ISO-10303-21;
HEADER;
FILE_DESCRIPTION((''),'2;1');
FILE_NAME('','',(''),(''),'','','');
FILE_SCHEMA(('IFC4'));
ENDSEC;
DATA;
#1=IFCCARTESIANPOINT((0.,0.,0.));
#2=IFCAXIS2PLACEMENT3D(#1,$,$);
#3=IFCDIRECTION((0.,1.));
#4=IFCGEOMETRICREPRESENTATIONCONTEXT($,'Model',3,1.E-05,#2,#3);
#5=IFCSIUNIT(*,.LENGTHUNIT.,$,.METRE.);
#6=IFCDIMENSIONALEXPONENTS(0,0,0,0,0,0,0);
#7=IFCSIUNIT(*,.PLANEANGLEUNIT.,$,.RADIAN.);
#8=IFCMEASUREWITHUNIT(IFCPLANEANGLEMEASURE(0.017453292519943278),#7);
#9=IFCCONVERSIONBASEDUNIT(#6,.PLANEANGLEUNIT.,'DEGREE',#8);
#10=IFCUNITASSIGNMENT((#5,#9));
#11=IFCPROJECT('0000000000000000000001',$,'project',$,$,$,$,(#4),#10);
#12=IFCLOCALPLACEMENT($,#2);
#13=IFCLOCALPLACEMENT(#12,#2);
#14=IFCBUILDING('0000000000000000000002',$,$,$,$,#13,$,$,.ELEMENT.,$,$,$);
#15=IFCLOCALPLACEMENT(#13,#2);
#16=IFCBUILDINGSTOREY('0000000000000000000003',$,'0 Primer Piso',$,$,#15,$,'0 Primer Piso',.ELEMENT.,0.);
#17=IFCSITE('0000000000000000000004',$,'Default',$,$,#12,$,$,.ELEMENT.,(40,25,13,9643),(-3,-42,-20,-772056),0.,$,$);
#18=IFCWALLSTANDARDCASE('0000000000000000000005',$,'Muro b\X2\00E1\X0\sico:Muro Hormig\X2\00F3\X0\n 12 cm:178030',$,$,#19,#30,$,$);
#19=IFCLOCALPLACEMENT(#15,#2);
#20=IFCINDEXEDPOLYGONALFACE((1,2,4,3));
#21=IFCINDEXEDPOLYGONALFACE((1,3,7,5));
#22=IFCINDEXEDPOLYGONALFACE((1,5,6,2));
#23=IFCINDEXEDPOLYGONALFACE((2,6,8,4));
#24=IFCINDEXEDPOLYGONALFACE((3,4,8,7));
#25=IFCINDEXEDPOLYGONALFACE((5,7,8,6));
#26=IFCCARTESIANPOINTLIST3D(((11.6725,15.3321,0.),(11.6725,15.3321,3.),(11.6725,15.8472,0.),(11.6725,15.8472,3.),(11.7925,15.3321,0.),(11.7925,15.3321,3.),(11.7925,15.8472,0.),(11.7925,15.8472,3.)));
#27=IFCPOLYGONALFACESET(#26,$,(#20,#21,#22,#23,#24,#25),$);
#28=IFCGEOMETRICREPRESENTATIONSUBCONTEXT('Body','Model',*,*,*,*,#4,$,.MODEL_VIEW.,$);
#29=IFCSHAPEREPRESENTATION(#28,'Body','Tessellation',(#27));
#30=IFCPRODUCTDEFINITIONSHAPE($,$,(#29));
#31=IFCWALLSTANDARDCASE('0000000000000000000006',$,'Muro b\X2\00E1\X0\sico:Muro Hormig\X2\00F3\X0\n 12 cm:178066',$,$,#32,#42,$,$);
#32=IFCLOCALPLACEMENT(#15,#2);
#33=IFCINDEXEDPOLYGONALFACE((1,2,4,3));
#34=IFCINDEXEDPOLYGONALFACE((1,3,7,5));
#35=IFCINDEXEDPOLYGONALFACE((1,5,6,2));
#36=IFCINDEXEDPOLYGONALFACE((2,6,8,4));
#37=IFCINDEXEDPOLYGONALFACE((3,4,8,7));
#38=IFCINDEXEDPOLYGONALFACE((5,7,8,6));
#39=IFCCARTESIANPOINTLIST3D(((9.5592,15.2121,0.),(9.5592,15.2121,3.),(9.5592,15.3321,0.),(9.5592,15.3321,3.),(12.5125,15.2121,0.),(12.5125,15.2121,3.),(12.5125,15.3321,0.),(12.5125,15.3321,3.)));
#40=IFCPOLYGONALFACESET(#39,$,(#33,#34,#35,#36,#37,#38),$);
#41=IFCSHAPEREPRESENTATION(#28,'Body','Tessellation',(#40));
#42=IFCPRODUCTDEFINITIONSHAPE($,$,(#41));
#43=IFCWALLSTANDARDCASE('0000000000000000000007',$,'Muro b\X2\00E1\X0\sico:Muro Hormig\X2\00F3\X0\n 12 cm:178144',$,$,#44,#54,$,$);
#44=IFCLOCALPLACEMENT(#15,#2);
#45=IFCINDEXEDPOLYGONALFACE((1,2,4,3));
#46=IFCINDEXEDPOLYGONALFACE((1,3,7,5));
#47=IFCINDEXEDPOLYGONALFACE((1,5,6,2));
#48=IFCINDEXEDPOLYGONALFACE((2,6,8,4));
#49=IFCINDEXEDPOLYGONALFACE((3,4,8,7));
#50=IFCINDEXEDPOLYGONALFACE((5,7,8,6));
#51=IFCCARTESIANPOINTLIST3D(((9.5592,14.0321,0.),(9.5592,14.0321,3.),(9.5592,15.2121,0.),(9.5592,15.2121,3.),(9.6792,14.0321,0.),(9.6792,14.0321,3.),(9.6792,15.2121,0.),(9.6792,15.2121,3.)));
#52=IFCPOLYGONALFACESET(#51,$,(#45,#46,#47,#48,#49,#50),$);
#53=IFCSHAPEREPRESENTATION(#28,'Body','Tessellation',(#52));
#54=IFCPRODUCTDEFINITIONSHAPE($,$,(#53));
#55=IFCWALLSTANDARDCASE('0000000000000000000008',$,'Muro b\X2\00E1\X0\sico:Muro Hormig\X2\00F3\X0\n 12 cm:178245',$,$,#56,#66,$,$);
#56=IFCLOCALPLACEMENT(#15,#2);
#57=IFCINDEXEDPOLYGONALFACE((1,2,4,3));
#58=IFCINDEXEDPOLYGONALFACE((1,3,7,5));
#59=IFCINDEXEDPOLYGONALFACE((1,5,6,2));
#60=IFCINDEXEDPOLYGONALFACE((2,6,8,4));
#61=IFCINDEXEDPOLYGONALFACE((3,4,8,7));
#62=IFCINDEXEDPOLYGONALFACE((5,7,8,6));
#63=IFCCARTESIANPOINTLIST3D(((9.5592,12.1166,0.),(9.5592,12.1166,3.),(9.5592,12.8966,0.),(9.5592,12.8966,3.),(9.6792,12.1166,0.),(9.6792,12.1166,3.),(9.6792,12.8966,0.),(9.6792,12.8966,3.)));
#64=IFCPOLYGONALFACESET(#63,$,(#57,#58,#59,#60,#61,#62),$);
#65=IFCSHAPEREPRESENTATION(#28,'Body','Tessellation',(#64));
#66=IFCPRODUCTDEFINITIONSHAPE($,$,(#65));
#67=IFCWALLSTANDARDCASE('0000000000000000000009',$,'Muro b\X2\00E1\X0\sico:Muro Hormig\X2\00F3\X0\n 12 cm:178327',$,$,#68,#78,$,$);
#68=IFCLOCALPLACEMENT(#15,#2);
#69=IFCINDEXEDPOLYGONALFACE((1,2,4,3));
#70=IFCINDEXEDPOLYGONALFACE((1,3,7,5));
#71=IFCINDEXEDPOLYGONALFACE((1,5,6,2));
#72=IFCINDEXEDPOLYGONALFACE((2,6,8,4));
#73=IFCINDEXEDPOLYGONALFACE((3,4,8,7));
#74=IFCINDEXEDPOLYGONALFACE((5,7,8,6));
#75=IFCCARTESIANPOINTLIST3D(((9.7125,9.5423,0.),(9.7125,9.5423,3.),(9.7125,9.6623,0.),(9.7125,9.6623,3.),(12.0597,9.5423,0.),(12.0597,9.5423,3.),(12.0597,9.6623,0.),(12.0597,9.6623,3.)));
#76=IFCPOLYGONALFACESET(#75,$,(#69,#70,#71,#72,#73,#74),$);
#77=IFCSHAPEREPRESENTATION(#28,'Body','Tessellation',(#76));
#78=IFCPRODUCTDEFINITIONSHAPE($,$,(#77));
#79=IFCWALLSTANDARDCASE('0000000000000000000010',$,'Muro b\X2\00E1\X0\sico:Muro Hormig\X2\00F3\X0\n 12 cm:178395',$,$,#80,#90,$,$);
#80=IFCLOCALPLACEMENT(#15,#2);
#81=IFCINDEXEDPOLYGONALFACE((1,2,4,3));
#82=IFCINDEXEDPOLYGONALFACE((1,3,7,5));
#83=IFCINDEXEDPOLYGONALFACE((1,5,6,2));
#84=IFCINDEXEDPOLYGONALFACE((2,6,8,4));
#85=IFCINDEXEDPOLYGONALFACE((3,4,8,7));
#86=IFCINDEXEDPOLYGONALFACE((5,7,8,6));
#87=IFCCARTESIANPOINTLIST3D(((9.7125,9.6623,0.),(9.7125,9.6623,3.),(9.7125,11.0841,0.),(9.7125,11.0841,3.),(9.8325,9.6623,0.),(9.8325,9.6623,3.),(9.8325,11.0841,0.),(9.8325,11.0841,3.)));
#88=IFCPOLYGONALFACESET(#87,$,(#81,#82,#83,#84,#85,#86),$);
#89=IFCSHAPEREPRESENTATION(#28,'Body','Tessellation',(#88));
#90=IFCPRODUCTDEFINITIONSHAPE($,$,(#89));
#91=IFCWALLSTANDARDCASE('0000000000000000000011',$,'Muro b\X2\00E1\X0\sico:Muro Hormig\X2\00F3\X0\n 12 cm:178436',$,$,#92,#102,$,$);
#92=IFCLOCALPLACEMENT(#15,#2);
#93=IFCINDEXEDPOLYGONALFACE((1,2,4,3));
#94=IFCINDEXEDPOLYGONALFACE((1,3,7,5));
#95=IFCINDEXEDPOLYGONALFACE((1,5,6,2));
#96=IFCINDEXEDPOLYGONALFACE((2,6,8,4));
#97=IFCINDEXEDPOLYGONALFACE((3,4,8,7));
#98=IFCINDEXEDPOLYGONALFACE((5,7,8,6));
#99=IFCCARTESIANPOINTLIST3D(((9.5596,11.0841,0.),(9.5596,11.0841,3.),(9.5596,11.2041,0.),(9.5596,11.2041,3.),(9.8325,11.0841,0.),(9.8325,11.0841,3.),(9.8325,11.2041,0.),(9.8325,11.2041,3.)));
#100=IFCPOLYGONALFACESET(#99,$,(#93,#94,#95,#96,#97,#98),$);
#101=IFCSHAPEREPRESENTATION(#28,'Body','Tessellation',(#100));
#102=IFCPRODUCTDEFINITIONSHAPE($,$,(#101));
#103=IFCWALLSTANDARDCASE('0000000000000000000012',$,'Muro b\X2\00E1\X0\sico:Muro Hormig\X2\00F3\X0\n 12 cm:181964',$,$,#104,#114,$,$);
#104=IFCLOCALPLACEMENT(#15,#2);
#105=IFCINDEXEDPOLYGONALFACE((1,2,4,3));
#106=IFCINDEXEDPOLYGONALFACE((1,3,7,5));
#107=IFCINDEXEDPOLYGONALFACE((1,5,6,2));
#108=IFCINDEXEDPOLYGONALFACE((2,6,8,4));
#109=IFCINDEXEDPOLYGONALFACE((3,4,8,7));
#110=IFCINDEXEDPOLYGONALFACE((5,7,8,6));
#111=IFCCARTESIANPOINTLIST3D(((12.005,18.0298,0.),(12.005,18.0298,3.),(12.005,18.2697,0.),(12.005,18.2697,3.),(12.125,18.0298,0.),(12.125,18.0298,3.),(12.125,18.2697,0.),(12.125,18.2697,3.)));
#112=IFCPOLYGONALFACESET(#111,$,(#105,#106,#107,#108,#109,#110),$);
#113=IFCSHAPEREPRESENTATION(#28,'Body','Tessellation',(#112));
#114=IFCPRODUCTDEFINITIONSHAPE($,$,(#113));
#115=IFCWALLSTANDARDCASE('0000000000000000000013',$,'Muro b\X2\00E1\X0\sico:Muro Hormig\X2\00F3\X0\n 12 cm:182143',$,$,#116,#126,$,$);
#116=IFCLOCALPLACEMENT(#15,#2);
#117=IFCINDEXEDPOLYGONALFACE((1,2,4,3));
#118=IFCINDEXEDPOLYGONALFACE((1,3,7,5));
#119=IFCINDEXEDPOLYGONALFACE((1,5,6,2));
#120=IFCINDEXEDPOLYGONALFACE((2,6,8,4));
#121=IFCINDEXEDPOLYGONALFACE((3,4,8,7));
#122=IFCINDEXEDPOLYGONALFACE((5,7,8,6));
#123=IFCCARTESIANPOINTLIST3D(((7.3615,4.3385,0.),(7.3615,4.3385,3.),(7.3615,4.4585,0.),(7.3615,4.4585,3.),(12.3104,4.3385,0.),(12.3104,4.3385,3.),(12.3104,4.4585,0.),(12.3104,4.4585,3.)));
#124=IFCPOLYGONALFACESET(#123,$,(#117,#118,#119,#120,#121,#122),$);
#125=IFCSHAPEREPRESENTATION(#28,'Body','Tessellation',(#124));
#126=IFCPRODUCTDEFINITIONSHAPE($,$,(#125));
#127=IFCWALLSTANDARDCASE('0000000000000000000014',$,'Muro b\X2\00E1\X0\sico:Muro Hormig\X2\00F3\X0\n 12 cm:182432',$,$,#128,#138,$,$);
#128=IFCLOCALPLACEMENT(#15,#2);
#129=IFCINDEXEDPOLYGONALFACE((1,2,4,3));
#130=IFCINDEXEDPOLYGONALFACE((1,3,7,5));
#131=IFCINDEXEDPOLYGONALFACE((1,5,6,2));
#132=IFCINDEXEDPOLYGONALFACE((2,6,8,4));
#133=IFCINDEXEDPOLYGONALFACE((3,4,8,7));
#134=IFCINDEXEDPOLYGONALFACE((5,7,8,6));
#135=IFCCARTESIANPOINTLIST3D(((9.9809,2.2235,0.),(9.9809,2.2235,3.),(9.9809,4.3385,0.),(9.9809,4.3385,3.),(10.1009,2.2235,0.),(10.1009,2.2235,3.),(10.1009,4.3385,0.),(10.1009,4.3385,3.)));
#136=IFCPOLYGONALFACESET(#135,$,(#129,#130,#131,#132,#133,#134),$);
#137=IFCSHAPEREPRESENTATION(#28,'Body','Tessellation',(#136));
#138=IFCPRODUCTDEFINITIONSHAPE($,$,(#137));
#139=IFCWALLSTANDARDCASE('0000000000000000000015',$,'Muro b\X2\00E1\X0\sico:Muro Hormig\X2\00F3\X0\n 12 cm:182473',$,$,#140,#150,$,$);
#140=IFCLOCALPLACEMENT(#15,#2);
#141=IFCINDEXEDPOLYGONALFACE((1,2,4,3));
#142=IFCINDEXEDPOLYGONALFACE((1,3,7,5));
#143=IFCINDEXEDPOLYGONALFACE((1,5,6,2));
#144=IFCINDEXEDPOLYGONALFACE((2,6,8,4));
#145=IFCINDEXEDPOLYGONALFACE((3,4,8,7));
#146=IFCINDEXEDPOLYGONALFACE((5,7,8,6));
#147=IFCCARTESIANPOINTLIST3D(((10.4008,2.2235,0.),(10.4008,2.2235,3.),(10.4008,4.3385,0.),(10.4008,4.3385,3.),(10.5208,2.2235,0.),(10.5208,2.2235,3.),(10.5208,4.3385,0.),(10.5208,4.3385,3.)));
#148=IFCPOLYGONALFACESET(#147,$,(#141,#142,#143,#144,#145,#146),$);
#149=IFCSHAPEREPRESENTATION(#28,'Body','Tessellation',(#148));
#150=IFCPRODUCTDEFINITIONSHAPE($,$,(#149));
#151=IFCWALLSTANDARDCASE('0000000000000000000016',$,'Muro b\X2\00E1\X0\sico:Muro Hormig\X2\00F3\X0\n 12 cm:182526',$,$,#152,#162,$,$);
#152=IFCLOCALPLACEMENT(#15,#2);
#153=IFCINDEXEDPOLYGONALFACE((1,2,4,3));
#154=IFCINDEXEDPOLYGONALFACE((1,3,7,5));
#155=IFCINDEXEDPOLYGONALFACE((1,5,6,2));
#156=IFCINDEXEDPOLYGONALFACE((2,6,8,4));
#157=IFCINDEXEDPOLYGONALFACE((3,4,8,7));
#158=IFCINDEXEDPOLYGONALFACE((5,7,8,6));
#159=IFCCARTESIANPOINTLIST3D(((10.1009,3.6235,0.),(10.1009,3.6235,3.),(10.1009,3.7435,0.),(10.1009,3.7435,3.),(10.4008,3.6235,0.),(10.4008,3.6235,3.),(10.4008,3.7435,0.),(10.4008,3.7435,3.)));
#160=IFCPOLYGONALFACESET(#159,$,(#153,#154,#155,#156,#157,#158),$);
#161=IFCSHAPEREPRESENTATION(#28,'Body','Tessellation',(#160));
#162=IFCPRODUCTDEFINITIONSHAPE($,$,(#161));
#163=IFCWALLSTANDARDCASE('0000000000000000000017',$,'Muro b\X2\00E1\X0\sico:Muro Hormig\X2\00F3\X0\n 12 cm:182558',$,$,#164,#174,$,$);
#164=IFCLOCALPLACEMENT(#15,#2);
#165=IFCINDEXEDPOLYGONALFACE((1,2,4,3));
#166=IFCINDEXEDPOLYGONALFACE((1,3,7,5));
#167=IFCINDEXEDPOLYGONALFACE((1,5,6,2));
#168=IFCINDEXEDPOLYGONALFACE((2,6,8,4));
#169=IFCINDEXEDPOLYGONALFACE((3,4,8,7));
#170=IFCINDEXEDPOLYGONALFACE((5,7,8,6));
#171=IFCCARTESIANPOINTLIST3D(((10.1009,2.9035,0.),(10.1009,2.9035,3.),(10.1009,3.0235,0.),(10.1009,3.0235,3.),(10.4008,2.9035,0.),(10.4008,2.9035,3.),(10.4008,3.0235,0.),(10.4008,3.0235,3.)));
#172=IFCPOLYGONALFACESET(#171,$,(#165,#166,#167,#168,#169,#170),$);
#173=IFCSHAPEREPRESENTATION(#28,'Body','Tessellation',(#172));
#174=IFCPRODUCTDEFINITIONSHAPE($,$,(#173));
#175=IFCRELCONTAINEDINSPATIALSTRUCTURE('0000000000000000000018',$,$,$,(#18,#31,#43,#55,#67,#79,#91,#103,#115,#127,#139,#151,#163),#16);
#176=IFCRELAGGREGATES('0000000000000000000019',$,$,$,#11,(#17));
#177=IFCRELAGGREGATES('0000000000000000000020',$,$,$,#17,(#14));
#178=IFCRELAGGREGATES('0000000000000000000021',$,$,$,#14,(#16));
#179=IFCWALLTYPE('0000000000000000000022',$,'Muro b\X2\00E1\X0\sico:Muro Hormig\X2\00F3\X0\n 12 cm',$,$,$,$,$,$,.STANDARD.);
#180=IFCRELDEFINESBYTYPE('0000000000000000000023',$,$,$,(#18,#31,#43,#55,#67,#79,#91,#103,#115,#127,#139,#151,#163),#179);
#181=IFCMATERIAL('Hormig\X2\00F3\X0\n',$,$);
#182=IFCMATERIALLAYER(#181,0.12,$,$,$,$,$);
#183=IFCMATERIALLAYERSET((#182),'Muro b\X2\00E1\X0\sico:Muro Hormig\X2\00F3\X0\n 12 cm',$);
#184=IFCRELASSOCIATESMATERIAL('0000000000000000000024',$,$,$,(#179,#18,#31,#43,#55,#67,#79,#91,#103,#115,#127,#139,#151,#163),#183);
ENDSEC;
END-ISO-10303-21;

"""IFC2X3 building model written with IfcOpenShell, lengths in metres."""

from ifc_helpers import new_model, entity, si_unit, converted_unit, direction, frame, frame_2d, origin, place, context, subcontext, project, spatial, rectangle, extrude, material, layer, layer_set, layer_usage, type_object, element, save


model = new_model("IFC2X3")

# Units and contexts
model_context = context("Model", 3, precision=1e-05, world=origin(), true_north=direction((0.0, 1.0)))
body_context = subcontext(model_context, "Body", "Model", "MODEL_VIEW")
ifc_project = project(units=[si_unit("LENGTHUNIT", "METRE"), converted_unit("PLANEANGLEUNIT", "DEGREE", entity("IfcPlaneAngleMeasure", 0.017453292519943278), si_unit("PLANEANGLEUNIT", "RADIAN"), dimensions=[0, 0, 0, 0, 0, 0, 0])], contexts=[model_context])

# Site, building, storey
site_placement = place(None, origin())
site = spatial("IfcSite", under=ifc_project, at=site_placement, Name="Default", CompositionType="ELEMENT", RefLatitude=(40, 25, 13, 9643), RefLongitude=(-3, -42, -20, -772056), RefElevation=0.0)
building_placement = place(site_placement, origin())
building = spatial("IfcBuilding", under=site, at=building_placement, CompositionType="ELEMENT")
storey_placement = place(building_placement, origin())
storey = spatial("IfcBuildingStorey", under=building, at=storey_placement, Name="0 Primer Piso", LongName="0 Primer Piso", CompositionType="ELEMENT", Elevation=0.0)

# Shared definitions
ifc_material = material(Name="Hormigón")
ifc_layer = layer(ifc_material, 0.12)
ifc_layer_set = layer_set([ifc_layer], Name="Muro básico:Muro Hormigón 12 cm")
wall_type = type_object("IfcWallType", Name="Muro básico:Muro Hormigón 12 cm", PredefinedType="STANDARD", material=ifc_layer_set)

# Walls
ifc_layer_usage_1 = layer_usage(ifc_layer_set, "AXIS2", "NEGATIVE", 0.06)
wall_1_placement = place(storey_placement, frame((11.7325, 15.8472, 0.0), z_axis=(0.0, 0.0, 1.0), x_axis=(0.0, -1.0, 0.0)))
element("IfcWallStandardCase", 1, at=wall_1_placement, inside=storey, type_object=wall_type, material=ifc_layer_usage_1, Name="Muro básico:Muro Hormigón 12 cm:178030", context=body_context, shape_type="SweptSolid", body=[
    extrude(rectangle(XDim=0.5151, YDim=0.12, at=frame_2d((0.2575, 0.0), x_axis=(-1.0, 0.0))), origin(), (0.0, 0.0, 1.0), 3.0),
])
ifc_layer_usage_2 = layer_usage(ifc_layer_set, "AXIS2", "NEGATIVE", 0.06)
wall_2_placement = place(storey_placement, frame((9.5592, 15.2721, 0.0)))
element("IfcWallStandardCase", 2, at=wall_2_placement, inside=storey, type_object=wall_type, material=ifc_layer_usage_2, Name="Muro básico:Muro Hormigón 12 cm:178066", context=body_context, shape_type="SweptSolid", body=[
    extrude(rectangle(XDim=2.9533, YDim=0.12, at=frame_2d((1.4767, 0.0), x_axis=(-1.0, 0.0))), origin(), (0.0, 0.0, 1.0), 3.0),
])
ifc_layer_usage_3 = layer_usage(ifc_layer_set, "AXIS2", "NEGATIVE", 0.06)
wall_3_placement = place(storey_placement, frame((9.6192, 15.2121, 0.0), z_axis=(0.0, 0.0, 1.0), x_axis=(0.0, -1.0, 0.0)))
element("IfcWallStandardCase", 3, at=wall_3_placement, inside=storey, type_object=wall_type, material=ifc_layer_usage_3, Name="Muro básico:Muro Hormigón 12 cm:178144", context=body_context, shape_type="SweptSolid", body=[
    extrude(rectangle(XDim=1.18, YDim=0.12, at=frame_2d((0.59, 0.0), x_axis=(-1.0, 0.0))), origin(), (0.0, 0.0, 1.0), 3.0),
])
ifc_layer_usage_4 = layer_usage(ifc_layer_set, "AXIS2", "NEGATIVE", 0.06)
wall_4_placement = place(storey_placement, frame((9.6192, 12.8966, 0.0), z_axis=(0.0, 0.0, 1.0), x_axis=(0.0, -1.0, 0.0)))
element("IfcWallStandardCase", 4, at=wall_4_placement, inside=storey, type_object=wall_type, material=ifc_layer_usage_4, Name="Muro básico:Muro Hormigón 12 cm:178245", context=body_context, shape_type="SweptSolid", body=[
    extrude(rectangle(XDim=0.78, YDim=0.12, at=frame_2d((0.39, 0.0), x_axis=(-1.0, 0.0))), origin(), (0.0, 0.0, 1.0), 3.0),
])
ifc_layer_usage_5 = layer_usage(ifc_layer_set, "AXIS2", "NEGATIVE", 0.06)
wall_5_placement = place(storey_placement, frame((12.0597, 9.6023, 0.0), z_axis=(0.0, 0.0, 1.0), x_axis=(-1.0, 0.0, 0.0)))
element("IfcWallStandardCase", 5, at=wall_5_placement, inside=storey, type_object=wall_type, material=ifc_layer_usage_5, Name="Muro básico:Muro Hormigón 12 cm:178327", context=body_context, shape_type="SweptSolid", body=[
    extrude(rectangle(XDim=2.3472, YDim=0.12, at=frame_2d((1.1736, 0.0), x_axis=(-1.0, 0.0))), origin(), (0.0, 0.0, 1.0), 3.0),
])
ifc_layer_usage_6 = layer_usage(ifc_layer_set, "AXIS2", "NEGATIVE", 0.06)
wall_6_placement = place(storey_placement, frame((9.7725, 9.6623, 0.0), z_axis=(0.0, 0.0, 1.0), x_axis=(0.0, 1.0, 0.0)))
element("IfcWallStandardCase", 6, at=wall_6_placement, inside=storey, type_object=wall_type, material=ifc_layer_usage_6, Name="Muro básico:Muro Hormigón 12 cm:178395", context=body_context, shape_type="SweptSolid", body=[
    extrude(rectangle(XDim=1.4219, YDim=0.12, at=frame_2d((0.7109, 0.0), x_axis=(-1.0, 0.0))), origin(), (0.0, 0.0, 1.0), 3.0),
])
ifc_layer_usage_7 = layer_usage(ifc_layer_set, "AXIS2", "NEGATIVE", 0.06)
wall_7_placement = place(storey_placement, frame((9.8325, 11.1441, 0.0), z_axis=(0.0, 0.0, 1.0), x_axis=(-1.0, 0.0, 0.0)))
element("IfcWallStandardCase", 7, at=wall_7_placement, inside=storey, type_object=wall_type, material=ifc_layer_usage_7, Name="Muro básico:Muro Hormigón 12 cm:178436", context=body_context, shape_type="SweptSolid", body=[
    extrude(rectangle(XDim=0.2729, YDim=0.12, at=frame_2d((0.1365, 0.0), x_axis=(-1.0, 0.0))), origin(), (0.0, 0.0, 1.0), 3.0),
])
ifc_layer_usage_8 = layer_usage(ifc_layer_set, "AXIS2", "NEGATIVE", 0.06)
wall_8_placement = place(storey_placement, frame((12.065, 18.2697, 0.0), z_axis=(0.0, 0.0, 1.0), x_axis=(0.0, -1.0, 0.0)))
element("IfcWallStandardCase", 8, at=wall_8_placement, inside=storey, type_object=wall_type, material=ifc_layer_usage_8, Name="Muro básico:Muro Hormigón 12 cm:181964", context=body_context, shape_type="SweptSolid", body=[
    extrude(rectangle(XDim=0.24, YDim=0.12, at=frame_2d((0.12, 0.0), x_axis=(-1.0, 0.0))), origin(), (0.0, 0.0, 1.0), 3.0),
])
ifc_layer_usage_9 = layer_usage(ifc_layer_set, "AXIS2", "NEGATIVE", 0.06)
wall_9_placement = place(storey_placement, frame((7.3615, 4.3985, 0.0)))
element("IfcWallStandardCase", 9, at=wall_9_placement, inside=storey, type_object=wall_type, material=ifc_layer_usage_9, Name="Muro básico:Muro Hormigón 12 cm:182143", context=body_context, shape_type="SweptSolid", body=[
    extrude(rectangle(XDim=4.9489, YDim=0.12, at=frame_2d((2.4745, 0.0), x_axis=(-1.0, 0.0))), origin(), (0.0, 0.0, 1.0), 3.0),
])
ifc_layer_usage_10 = layer_usage(ifc_layer_set, "AXIS2", "NEGATIVE", 0.06)
wall_10_placement = place(storey_placement, frame((10.0409, 4.3385, 0.0), z_axis=(0.0, 0.0, 1.0), x_axis=(0.0, -1.0, 0.0)))
element("IfcWallStandardCase", 10, at=wall_10_placement, inside=storey, type_object=wall_type, material=ifc_layer_usage_10, Name="Muro básico:Muro Hormigón 12 cm:182432", context=body_context, shape_type="SweptSolid", body=[
    extrude(rectangle(XDim=2.115, YDim=0.12, at=frame_2d((1.0575, 0.0), x_axis=(-1.0, 0.0))), origin(), (0.0, 0.0, 1.0), 3.0),
])
ifc_layer_usage_11 = layer_usage(ifc_layer_set, "AXIS2", "NEGATIVE", 0.06)
wall_11_placement = place(storey_placement, frame((10.4608, 4.3385, 0.0), z_axis=(0.0, 0.0, 1.0), x_axis=(0.0, -1.0, 0.0)))
element("IfcWallStandardCase", 11, at=wall_11_placement, inside=storey, type_object=wall_type, material=ifc_layer_usage_11, Name="Muro básico:Muro Hormigón 12 cm:182473", context=body_context, shape_type="SweptSolid", body=[
    extrude(rectangle(XDim=2.115, YDim=0.12, at=frame_2d((1.0575, 0.0), x_axis=(-1.0, 0.0))), origin(), (0.0, 0.0, 1.0), 3.0),
])
ifc_layer_usage_12 = layer_usage(ifc_layer_set, "AXIS2", "NEGATIVE", 0.06)
wall_12_placement = place(storey_placement, frame((10.1009, 3.6835, 0.0)))
element("IfcWallStandardCase", 12, at=wall_12_placement, inside=storey, type_object=wall_type, material=ifc_layer_usage_12, Name="Muro básico:Muro Hormigón 12 cm:182526", context=body_context, shape_type="SweptSolid", body=[
    extrude(rectangle(XDim=0.2999, YDim=0.12, at=frame_2d((0.15, 0.0), x_axis=(-1.0, 0.0))), origin(), (0.0, 0.0, 1.0), 3.0),
])
ifc_layer_usage_13 = layer_usage(ifc_layer_set, "AXIS2", "NEGATIVE", 0.06)
wall_13_placement = place(storey_placement, frame((10.1009, 2.9635, 0.0)))
element("IfcWallStandardCase", 13, at=wall_13_placement, inside=storey, type_object=wall_type, material=ifc_layer_usage_13, Name="Muro básico:Muro Hormigón 12 cm:182558", context=body_context, shape_type="SweptSolid", body=[
    extrude(rectangle(XDim=0.2999, YDim=0.12, at=frame_2d((0.15, 0.0), x_axis=(-1.0, 0.0))), origin(), (0.0, 0.0, 1.0), 3.0),
])

save(model, "model.ifc")
